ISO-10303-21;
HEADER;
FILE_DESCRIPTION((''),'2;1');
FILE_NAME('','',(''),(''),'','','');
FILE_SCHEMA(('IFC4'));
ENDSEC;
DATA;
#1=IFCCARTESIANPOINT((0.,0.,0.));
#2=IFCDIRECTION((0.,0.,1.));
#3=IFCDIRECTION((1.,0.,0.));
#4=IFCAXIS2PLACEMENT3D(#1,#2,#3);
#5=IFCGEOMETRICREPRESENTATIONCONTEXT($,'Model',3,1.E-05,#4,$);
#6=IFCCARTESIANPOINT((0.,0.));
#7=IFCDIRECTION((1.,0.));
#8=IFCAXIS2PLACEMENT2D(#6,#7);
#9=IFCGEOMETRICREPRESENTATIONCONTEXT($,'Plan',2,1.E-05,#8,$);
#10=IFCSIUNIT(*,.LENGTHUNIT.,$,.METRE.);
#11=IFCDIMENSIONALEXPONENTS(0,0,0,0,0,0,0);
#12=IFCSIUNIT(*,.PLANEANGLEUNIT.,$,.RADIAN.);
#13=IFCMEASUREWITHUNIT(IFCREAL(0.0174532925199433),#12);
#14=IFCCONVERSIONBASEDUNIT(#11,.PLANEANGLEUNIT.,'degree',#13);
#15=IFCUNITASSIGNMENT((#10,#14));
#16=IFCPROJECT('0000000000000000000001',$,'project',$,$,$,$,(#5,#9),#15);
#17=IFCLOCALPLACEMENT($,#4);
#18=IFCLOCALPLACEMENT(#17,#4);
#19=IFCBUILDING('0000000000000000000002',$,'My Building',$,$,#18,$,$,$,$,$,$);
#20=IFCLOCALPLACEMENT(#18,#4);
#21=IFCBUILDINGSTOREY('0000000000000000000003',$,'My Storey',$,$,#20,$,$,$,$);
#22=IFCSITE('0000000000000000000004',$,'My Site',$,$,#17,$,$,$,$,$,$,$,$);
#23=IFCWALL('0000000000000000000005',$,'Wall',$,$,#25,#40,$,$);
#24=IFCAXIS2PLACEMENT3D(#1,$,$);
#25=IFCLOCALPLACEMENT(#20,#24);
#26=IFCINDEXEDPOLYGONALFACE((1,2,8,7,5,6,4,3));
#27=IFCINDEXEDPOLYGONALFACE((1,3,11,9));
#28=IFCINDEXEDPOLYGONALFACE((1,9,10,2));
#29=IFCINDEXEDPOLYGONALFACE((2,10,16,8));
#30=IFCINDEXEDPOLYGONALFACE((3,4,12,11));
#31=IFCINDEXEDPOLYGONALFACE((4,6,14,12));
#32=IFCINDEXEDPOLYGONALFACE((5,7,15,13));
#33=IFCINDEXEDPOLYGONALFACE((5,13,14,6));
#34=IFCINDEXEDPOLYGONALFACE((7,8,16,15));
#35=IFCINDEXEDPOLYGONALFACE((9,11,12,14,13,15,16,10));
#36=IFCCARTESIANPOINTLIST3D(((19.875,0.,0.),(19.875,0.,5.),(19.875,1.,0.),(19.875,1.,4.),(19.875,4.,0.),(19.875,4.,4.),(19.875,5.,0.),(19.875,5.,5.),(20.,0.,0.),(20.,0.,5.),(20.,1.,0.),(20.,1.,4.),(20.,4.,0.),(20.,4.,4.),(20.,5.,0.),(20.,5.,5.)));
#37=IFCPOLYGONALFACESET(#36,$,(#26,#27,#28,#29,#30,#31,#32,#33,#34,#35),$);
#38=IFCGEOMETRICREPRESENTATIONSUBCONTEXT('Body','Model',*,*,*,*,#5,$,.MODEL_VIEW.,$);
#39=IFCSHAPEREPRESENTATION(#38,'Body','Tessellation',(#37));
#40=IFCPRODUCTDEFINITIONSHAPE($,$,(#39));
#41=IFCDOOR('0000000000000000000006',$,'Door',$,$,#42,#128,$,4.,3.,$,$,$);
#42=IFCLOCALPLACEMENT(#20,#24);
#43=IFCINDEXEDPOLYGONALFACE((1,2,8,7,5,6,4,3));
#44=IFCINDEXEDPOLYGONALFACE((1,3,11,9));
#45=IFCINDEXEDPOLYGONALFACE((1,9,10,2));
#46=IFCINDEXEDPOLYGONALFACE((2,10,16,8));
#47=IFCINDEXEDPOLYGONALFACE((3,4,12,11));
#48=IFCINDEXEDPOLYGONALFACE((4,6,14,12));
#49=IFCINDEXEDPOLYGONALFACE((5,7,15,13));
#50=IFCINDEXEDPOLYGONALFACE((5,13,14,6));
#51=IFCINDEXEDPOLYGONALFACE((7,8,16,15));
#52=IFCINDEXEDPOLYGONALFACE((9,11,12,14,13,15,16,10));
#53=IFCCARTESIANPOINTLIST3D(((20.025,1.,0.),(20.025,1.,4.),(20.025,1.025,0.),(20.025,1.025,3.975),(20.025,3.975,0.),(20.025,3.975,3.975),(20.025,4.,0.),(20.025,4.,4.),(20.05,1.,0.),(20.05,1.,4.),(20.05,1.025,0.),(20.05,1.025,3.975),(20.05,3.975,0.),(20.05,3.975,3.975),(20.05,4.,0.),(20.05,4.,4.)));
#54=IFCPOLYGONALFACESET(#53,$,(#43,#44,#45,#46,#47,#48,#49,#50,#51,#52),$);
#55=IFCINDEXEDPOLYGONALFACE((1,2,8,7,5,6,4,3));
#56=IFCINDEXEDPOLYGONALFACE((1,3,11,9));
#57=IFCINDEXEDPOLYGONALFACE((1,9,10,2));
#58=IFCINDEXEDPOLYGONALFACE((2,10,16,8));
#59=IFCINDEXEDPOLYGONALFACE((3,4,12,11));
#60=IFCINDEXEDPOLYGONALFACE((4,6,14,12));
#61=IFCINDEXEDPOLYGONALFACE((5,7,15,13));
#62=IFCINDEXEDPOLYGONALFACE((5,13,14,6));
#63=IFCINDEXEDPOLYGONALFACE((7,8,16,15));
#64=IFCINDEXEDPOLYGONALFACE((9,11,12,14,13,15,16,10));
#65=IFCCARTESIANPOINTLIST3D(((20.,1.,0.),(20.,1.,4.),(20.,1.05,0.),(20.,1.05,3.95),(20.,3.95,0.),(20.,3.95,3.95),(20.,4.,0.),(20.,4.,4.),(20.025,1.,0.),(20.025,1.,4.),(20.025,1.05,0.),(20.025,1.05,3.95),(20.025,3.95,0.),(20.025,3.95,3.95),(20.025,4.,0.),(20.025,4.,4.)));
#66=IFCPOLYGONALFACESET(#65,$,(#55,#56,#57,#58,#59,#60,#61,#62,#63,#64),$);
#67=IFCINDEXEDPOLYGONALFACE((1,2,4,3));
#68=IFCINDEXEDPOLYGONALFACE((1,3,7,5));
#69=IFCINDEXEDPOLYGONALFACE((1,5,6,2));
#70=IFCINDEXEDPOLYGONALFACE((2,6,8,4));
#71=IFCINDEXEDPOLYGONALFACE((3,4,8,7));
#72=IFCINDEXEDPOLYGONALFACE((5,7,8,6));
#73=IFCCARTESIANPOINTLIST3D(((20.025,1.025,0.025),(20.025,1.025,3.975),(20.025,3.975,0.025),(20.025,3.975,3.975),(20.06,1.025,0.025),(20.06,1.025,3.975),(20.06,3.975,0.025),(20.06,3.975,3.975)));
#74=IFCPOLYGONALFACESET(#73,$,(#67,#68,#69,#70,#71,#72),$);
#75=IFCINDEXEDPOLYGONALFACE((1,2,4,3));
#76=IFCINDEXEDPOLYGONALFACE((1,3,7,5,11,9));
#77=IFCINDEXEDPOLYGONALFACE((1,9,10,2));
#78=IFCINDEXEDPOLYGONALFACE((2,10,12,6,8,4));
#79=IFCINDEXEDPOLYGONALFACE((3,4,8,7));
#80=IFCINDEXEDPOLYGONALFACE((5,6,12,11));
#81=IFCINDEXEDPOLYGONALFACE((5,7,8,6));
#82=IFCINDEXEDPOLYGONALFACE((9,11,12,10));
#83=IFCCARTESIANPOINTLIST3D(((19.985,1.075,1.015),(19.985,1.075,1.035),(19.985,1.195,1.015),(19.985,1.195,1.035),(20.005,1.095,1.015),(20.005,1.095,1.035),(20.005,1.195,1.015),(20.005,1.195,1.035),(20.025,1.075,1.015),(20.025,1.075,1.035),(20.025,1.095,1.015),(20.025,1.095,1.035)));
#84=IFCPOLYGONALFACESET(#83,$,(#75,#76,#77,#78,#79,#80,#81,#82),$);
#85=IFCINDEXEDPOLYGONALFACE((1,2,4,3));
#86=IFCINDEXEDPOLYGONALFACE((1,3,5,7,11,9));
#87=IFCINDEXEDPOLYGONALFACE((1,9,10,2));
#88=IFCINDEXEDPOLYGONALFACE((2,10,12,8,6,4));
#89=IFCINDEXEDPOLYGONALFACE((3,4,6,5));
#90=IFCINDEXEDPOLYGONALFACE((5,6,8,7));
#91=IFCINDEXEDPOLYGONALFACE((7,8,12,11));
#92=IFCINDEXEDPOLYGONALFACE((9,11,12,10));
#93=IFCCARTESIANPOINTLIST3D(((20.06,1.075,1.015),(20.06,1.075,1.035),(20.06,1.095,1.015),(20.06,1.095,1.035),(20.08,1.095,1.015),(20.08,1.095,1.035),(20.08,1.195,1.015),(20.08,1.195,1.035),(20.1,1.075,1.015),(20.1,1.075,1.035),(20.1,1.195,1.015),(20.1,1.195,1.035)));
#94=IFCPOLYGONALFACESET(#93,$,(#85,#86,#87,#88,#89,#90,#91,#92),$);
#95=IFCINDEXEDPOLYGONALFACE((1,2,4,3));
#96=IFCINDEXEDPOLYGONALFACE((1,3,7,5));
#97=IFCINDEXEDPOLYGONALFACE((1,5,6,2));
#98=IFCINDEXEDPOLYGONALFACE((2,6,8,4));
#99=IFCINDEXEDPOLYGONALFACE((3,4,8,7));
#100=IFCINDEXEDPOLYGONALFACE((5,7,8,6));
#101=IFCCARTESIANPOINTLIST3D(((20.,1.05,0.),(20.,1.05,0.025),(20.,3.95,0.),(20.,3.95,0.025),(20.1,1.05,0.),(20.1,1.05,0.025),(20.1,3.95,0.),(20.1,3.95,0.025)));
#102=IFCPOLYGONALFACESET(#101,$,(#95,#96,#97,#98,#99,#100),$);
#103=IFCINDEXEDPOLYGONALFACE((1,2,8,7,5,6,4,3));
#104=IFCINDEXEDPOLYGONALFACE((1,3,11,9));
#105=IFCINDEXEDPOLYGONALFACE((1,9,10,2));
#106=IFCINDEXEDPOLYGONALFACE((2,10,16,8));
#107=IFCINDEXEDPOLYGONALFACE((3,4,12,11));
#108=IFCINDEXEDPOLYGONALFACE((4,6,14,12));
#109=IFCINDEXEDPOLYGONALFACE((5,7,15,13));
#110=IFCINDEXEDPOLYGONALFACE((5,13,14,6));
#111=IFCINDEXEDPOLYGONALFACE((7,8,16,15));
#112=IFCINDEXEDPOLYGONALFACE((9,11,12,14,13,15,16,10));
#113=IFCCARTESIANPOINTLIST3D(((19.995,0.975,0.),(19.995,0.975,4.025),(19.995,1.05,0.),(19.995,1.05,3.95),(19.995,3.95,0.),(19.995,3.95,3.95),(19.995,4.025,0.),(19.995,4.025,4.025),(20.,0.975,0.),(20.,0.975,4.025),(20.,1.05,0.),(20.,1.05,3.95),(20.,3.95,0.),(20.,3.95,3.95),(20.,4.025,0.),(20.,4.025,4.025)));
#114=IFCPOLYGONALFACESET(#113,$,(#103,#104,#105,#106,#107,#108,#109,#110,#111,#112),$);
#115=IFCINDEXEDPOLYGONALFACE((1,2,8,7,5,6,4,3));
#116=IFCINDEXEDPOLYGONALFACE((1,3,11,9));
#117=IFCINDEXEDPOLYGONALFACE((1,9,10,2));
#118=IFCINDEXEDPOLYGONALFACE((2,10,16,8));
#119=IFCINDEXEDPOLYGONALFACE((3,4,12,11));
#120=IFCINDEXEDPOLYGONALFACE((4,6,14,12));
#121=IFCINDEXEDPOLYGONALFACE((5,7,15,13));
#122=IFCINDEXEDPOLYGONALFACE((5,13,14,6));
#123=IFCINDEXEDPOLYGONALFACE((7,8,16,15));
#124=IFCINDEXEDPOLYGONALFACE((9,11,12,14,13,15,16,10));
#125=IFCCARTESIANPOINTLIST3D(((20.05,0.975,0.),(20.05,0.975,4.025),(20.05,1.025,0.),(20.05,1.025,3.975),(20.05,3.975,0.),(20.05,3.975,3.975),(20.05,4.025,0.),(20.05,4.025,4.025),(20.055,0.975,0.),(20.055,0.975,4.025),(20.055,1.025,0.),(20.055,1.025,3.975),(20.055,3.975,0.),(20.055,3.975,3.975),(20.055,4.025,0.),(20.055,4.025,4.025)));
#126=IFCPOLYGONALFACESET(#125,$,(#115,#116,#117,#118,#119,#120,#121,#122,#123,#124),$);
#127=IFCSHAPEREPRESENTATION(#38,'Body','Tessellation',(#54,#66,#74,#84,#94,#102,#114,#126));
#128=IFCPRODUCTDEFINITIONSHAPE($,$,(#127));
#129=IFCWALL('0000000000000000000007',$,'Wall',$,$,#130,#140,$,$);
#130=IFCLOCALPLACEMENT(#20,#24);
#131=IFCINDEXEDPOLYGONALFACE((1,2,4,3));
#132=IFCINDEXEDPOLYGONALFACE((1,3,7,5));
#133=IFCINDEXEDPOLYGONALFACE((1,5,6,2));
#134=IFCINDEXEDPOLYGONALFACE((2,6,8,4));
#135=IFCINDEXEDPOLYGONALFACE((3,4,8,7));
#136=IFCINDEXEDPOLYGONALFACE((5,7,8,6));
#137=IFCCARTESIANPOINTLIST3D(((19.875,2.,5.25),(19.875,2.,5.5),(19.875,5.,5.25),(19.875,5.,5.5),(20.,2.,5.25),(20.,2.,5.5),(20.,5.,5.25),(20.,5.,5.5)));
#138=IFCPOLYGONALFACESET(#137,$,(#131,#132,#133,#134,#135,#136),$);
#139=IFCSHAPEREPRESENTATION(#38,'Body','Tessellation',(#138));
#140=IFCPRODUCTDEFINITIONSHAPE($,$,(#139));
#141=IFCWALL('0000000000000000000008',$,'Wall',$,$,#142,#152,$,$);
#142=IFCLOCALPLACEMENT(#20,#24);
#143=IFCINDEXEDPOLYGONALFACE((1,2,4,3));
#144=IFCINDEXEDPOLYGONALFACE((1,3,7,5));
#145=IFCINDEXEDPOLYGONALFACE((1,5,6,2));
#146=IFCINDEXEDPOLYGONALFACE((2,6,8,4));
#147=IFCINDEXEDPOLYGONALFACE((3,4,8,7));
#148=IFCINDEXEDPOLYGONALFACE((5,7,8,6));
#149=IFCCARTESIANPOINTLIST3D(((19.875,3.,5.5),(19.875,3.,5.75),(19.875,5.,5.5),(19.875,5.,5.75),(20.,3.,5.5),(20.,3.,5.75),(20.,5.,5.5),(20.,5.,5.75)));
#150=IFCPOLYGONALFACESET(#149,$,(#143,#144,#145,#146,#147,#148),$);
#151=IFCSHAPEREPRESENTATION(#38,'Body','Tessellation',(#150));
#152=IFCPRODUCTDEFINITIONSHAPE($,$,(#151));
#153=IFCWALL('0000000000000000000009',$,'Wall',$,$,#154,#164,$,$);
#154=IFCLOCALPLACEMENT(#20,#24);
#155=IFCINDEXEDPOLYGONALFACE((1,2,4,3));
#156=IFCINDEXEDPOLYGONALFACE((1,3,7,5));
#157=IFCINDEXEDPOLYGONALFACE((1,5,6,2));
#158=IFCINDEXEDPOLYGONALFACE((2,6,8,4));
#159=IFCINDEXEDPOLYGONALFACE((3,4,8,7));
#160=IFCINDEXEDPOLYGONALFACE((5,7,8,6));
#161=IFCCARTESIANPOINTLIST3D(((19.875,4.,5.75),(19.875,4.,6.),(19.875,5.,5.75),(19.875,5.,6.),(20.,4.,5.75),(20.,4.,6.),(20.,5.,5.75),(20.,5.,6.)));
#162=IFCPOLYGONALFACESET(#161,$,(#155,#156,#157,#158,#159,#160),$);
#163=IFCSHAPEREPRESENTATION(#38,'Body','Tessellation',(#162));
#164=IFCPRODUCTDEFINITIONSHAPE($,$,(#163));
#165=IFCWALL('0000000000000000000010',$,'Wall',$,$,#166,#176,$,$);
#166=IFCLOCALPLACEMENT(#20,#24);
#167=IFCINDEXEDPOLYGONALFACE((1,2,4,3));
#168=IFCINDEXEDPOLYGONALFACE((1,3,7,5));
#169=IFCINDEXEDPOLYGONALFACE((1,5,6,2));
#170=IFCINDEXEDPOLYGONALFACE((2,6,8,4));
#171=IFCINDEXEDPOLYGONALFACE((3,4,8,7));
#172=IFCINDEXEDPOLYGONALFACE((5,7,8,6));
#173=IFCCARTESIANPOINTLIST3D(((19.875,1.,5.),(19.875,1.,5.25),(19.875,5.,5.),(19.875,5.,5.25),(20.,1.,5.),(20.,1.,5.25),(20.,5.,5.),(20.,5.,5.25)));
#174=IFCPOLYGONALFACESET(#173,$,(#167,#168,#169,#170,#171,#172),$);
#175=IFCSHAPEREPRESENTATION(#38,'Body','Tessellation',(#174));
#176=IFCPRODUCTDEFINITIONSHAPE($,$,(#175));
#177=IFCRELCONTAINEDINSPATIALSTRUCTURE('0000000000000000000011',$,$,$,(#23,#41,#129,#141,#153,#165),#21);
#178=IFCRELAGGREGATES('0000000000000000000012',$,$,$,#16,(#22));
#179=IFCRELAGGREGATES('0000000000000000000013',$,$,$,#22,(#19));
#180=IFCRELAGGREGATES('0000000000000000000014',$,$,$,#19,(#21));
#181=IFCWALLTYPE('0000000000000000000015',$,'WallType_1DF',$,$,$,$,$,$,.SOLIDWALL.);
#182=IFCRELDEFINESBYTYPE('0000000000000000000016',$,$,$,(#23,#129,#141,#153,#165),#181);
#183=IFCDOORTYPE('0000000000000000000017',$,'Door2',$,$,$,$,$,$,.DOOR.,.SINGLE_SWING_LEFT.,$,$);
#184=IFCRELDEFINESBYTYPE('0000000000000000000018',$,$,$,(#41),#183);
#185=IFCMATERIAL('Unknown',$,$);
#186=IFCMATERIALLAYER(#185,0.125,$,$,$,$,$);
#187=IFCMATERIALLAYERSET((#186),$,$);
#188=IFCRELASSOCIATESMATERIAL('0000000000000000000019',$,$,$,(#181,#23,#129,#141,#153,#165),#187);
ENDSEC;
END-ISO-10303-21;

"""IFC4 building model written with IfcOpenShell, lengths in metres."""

from ifc_helpers import new_model, entity, si_unit, converted_unit, frame, origin_with_axes, origin_2d_with_axis, place, context, subcontext, project, spatial, line, indexed_curve, outline, extrude, shape, source, transform, mapped, material, layer, layer_set, layer_usage, type_object, type_shapes, element, fill, save


model = new_model("IFC4")

# Units and contexts
model_context = context("Model", 3, precision=1e-05, world=origin_with_axes())
plan_context = context("Plan", 2, precision=1e-05, world=origin_2d_with_axis())
body_context_1 = subcontext(model_context, "Body", "Model", "MODEL_VIEW")
body_context_2 = subcontext(plan_context, "Body", "Plan", "PLAN_VIEW")
ifc_project = project(units=[si_unit("LENGTHUNIT", "METRE"), converted_unit("PLANEANGLEUNIT", "degree", entity("IfcReal", 0.0174532925199433), si_unit("PLANEANGLEUNIT", "RADIAN"), dimensions=[0, 0, 0, 0, 0, 0, 0])], contexts=[model_context, plan_context])

# Site, building, storey
site_placement = place(None, origin_with_axes())
site = spatial("IfcSite", under=ifc_project, at=site_placement, Name="My Site")
building_placement = place(site_placement, origin_with_axes())
building = spatial("IfcBuilding", under=site, at=building_placement, Name="My Building")
storey_placement = place(building_placement, origin_with_axes())
storey = spatial("IfcBuildingStorey", under=building, at=storey_placement, Name="My Storey")

# Wall, opening, door
ifc_material = material(Name="Unknown")
ifc_layer_1 = layer(ifc_material, 0.125)
ifc_layer_set_1 = layer_set([ifc_layer_1])
ifc_layer_usage_1 = layer_usage(ifc_layer_set_1, "AXIS2", "POSITIVE", 0.0)
wall_type_1 = type_object("IfcWallType", Name="WallType_1DF", PredefinedType="SOLIDWALL", material=ifc_layer_set_1)
wall_1_placement = place(storey_placement, frame((20.0, 0.0, 0.0), z_axis=(0.0, 0.0, 1.0), x_axis=(0.0, 1.0, 0.0)))
wall_1 = element("IfcWall", 1, at=wall_1_placement, inside=storey, type_object=wall_type_1, material=ifc_layer_usage_1, Name="Wall", context=body_context_1, shape_type="SweptSolid", body=[
    extrude(outline(indexed_curve([(0.0, 0.0), (0.0, 0.125), (5.0, 0.125), (5.0, 0.0), (0.0, 0.0)], self_intersect=False)), origin_with_axes(), (0.0, 0.0, 1.0), 5.0),
])
shared_shape_1 = source(origin_with_axes(), body_context_1, "Body", "SweptSolid", [
    extrude(outline(indexed_curve([(0.0, 0.0), (3.0, 0.0), (3.0, 4.0), (0.0, 4.0)], segments=[line(1, 2, 3, 4, 1)])), frame((0.0, -0.1, 0.0), z_axis=(0.0, -1.0, 0.0), x_axis=(1.0, 0.0, 0.0)), (0.0, 0.0, -1.0), 0.45),
])
opening_placement = place(wall_1_placement, frame((1.0, 0.0, 0.0), z_axis=(0.0, 0.0, 1.0), x_axis=(1.0, 0.0, 0.0)))
opening = element("IfcOpeningElement", 2, at=opening_placement, cuts=wall_1, PredefinedType="OPENING", context=body_context_1, shape_type="MappedRepresentation", body=[
    mapped(shared_shape_1, transform((0.0, 0.0, 0.0), x_axis=(1.0, 0.0, 0.0), y_axis=(0.0, 1.0, 0.0), z_axis=(0.0, 0.0, 1.0), scale=1.0)),
])
door_type = type_object("IfcDoorType", Name="Door2", OperationType="SINGLE_SWING_LEFT", PredefinedType="DOOR")
shared_shape_2 = source(origin_with_axes(), body_context_1, "Body", "SweptSolid", [
    extrude(outline(indexed_curve([(0.0, 0.0), (0.0, 4.0), (3.0, 4.0), (3.0, 0.0), (2.975, 0.0), (2.975, 3.975), (0.025, 3.975), (0.025, 0.0)], segments=[line(1, 2, 3, 4, 5, 6, 7, 8, 1)])), frame((0.0, 0.025, 0.0), z_axis=(0.0, -1.0, 0.0), x_axis=(1.0, 0.0, 0.0)), (0.0, 0.0, -1.0), 0.025),
    extrude(outline(indexed_curve([(0.0, 0.0), (0.0, 4.0), (3.0, 4.0), (3.0, 0.0), (2.95, 0.0), (2.95, 3.95), (0.05, 3.95), (0.05, 0.0)], segments=[line(1, 2, 3, 4, 5, 6, 7, 8, 1)])), frame((0.0, 0.0, 0.0), z_axis=(0.0, -1.0, 0.0), x_axis=(1.0, 0.0, 0.0)), (0.0, 0.0, -1.0), 0.025),
    extrude(outline(indexed_curve([(0.0, 0.0), (2.95, 0.0), (2.95, 0.035), (0.0, 0.035)], segments=[line(1, 2, 3, 4, 1)])), frame((0.025, 0.025, 0.025), z_axis=(0.0, 0.0, 1.0), x_axis=(1.0, 0.0, 0.0)), (0.0, 0.0, 1.0), 3.95),
    extrude(outline(indexed_curve([(0.0, 0.0), (0.0, -0.04), (-0.12, -0.04), (-0.12, -0.02), (-0.02, -0.02), (-0.02, 0.0)], segments=[line(1, 2, 3, 4, 5, 6, 1)])), frame((2.925, 0.025, 1.015), z_axis=(0.0, 0.0, 1.0), x_axis=(1.0, 0.0, 0.0)), (0.0, 0.0, 1.0), 0.02),
    extrude(outline(indexed_curve([(0.0, 0.0), (0.0, 0.04), (-0.12, 0.04), (-0.12, 0.02), (-0.02, 0.02), (-0.02, 0.0)], segments=[line(1, 2, 3, 4, 5, 6, 1)])), frame((2.925, 0.06, 1.015), z_axis=(0.0, 0.0, 1.0), x_axis=(1.0, 0.0, 0.0)), (0.0, 0.0, 1.0), 0.02),
    extrude(outline(indexed_curve([(0.0, 0.0), (2.9, 0.0), (2.9, 0.1), (0.0, 0.1)], segments=[line(1, 2, 3, 4, 1)])), frame((0.05, 0.0, 0.0), z_axis=(0.0, 0.0, 1.0), x_axis=(1.0, 0.0, 0.0)), (0.0, 0.0, 1.0), 0.025),
    extrude(outline(indexed_curve([(0.0, 0.0), (0.0, 4.025), (3.05, 4.025), (3.05, 0.0), (2.975, 0.0), (2.975, 3.95), (0.075, 3.95), (0.075, 0.0)], segments=[line(1, 2, 3, 4, 5, 6, 7, 8, 1)])), frame((-0.025, -0.005, 0.0), z_axis=(0.0, -1.0, 0.0), x_axis=(1.0, 0.0, 0.0)), (0.0, 0.0, -1.0), 0.005),
    extrude(outline(indexed_curve([(0.0, 0.0), (0.0, 4.025), (3.05, 4.025), (3.05, 0.0), (3.0, 0.0), (3.0, 3.975), (0.05, 3.975), (0.05, 0.0)], segments=[line(1, 2, 3, 4, 5, 6, 7, 8, 1)])), frame((-0.025, 0.05, 0.0), z_axis=(0.0, -1.0, 0.0), x_axis=(1.0, 0.0, 0.0)), (0.0, 0.0, -1.0), 0.005),
])
shared_shape_3 = source(origin_with_axes(), body_context_2, "Body", "Curve2D", [
    entity("IfcIndexedPolyCurve", entity("IfcCartesianPointList2D", [[0.0, 0.0], [0.0, 0.05], [0.025, 0.05], [0.025, 0.025], [0.05, 0.025], [0.05, 0.0]]), [entity("IfcLineIndex", [1, 2, 3, 4, 5, 6, 1])]),
    entity("IfcIndexedPolyCurve", entity("IfcCartesianPointList2D", [[3.0, 0.0], [3.0, 0.05], [2.975, 0.05], [2.975, 0.025], [2.95, 0.025], [2.95, 0.0]]), [entity("IfcLineIndex", [1, 2, 3, 4, 5, 6, 1])]),
    entity("IfcTrimmedCurve", entity("IfcEllipse", entity("IfcAxis2Placement2D", entity("IfcCartesianPoint", [0.06, 0.05]), entity("IfcDirection", [1.0, 0.0])), 2.915, 2.95), [entity("IfcCartesianPoint", [2.975, 0.05])], [entity("IfcCartesianPoint", [0.06, 3.0])], True, "CARTESIAN"),
    entity("IfcIndexedPolyCurve", entity("IfcCartesianPointList2D", [[0.025, 0.05], [0.06, 0.05], [0.06, 3.0], [0.025, 3.0]]), [entity("IfcLineIndex", [1, 2, 3, 4, 1])]),
])
type_shapes(door_type, [shared_shape_2, shared_shape_3])
door_placement = place(opening_placement, frame((3.0, 0.0, 0.0), z_axis=(0.0, 0.0, 1.0), x_axis=(-1.0, 0.0, 0.0)))
door = element("IfcDoor", 3, at=door_placement, inside=storey, type_object=door_type, Name="Door", OverallHeight=4.0, OverallWidth=3.0, shapes=[
    shape(body_context_1, "Body", "MappedRepresentation", [mapped(shared_shape_2, transform((0.0, 0.0, 0.0), x_axis=(1.0, 0.0, 0.0), y_axis=(0.0, 1.0, 0.0), z_axis=(0.0, 0.0, 1.0), scale=1.0))]),
    shape(body_context_2, "Body", "MappedRepresentation", [mapped(shared_shape_3, transform((0.0, 0.0, 0.0), x_axis=(1.0, 0.0, 0.0), y_axis=(0.0, 1.0, 0.0), z_axis=(0.0, 0.0, 1.0), scale=1.0))]),
])
fill(opening, door)

# Walls
ifc_layer_usage_2 = layer_usage(ifc_layer_set_1, "AXIS2", "POSITIVE", 0.0)
wall_2_placement = place(storey_placement, frame((20.0, 2.0, 5.25), z_axis=(0.0, 0.0, 1.0), x_axis=(0.0, 1.0, 0.0)))
element("IfcWall", 4, at=wall_2_placement, inside=storey, type_object=wall_type_1, material=ifc_layer_usage_2, Name="Wall", context=body_context_1, shape_type="SweptSolid", body=[
    extrude(outline(indexed_curve([(0.0, 0.0), (0.0, 0.125), (3.0, 0.125), (3.0, 0.0), (0.0, 0.0)], self_intersect=False)), origin_with_axes(), (0.0, 0.0, 1.0), 0.25),
])
ifc_layer_usage_3 = layer_usage(ifc_layer_set_1, "AXIS2", "POSITIVE", 0.0)
wall_3_placement = place(storey_placement, frame((20.0, 3.0, 5.5), z_axis=(0.0, 0.0, 1.0), x_axis=(0.0, 1.0, 0.0)))
element("IfcWall", 5, at=wall_3_placement, inside=storey, type_object=wall_type_1, material=ifc_layer_usage_3, Name="Wall", context=body_context_1, shape_type="SweptSolid", body=[
    extrude(outline(indexed_curve([(0.0, 0.0), (0.0, 0.125), (2.0, 0.125), (2.0, 0.0), (0.0, 0.0)], self_intersect=False)), origin_with_axes(), (0.0, 0.0, 1.0), 0.25),
])
ifc_layer_usage_4 = layer_usage(ifc_layer_set_1, "AXIS2", "POSITIVE", 0.0)
wall_4_placement = place(storey_placement, frame((20.0, 4.0, 5.75), z_axis=(0.0, 0.0, 1.0), x_axis=(0.0, 1.0, 0.0)))
element("IfcWall", 6, at=wall_4_placement, inside=storey, type_object=wall_type_1, material=ifc_layer_usage_4, Name="Wall", context=body_context_1, shape_type="SweptSolid", body=[
    extrude(outline(indexed_curve([(0.0, 0.0), (0.0, 0.125), (1.0, 0.125), (1.0, 0.0), (0.0, 0.0)], self_intersect=False)), origin_with_axes(), (0.0, 0.0, 1.0), 0.25),
])
ifc_layer_usage_5 = layer_usage(ifc_layer_set_1, "AXIS2", "POSITIVE", 0.0)
wall_5_placement = place(storey_placement, frame((20.0, 1.0, 5.0), z_axis=(0.0, 0.0, 1.0), x_axis=(0.0, 1.0, 0.0)))
element("IfcWall", 7, at=wall_5_placement, inside=storey, type_object=wall_type_1, material=ifc_layer_usage_5, Name="Wall", context=body_context_1, shape_type="SweptSolid", body=[
    extrude(outline(indexed_curve([(0.0, 0.0), (0.0, 0.125), (4.0, 0.125), (4.0, 0.0), (0.0, 0.0)], self_intersect=False)), origin_with_axes(), (0.0, 0.0, 1.0), 0.25),
])

save(model, "model.ifc")
